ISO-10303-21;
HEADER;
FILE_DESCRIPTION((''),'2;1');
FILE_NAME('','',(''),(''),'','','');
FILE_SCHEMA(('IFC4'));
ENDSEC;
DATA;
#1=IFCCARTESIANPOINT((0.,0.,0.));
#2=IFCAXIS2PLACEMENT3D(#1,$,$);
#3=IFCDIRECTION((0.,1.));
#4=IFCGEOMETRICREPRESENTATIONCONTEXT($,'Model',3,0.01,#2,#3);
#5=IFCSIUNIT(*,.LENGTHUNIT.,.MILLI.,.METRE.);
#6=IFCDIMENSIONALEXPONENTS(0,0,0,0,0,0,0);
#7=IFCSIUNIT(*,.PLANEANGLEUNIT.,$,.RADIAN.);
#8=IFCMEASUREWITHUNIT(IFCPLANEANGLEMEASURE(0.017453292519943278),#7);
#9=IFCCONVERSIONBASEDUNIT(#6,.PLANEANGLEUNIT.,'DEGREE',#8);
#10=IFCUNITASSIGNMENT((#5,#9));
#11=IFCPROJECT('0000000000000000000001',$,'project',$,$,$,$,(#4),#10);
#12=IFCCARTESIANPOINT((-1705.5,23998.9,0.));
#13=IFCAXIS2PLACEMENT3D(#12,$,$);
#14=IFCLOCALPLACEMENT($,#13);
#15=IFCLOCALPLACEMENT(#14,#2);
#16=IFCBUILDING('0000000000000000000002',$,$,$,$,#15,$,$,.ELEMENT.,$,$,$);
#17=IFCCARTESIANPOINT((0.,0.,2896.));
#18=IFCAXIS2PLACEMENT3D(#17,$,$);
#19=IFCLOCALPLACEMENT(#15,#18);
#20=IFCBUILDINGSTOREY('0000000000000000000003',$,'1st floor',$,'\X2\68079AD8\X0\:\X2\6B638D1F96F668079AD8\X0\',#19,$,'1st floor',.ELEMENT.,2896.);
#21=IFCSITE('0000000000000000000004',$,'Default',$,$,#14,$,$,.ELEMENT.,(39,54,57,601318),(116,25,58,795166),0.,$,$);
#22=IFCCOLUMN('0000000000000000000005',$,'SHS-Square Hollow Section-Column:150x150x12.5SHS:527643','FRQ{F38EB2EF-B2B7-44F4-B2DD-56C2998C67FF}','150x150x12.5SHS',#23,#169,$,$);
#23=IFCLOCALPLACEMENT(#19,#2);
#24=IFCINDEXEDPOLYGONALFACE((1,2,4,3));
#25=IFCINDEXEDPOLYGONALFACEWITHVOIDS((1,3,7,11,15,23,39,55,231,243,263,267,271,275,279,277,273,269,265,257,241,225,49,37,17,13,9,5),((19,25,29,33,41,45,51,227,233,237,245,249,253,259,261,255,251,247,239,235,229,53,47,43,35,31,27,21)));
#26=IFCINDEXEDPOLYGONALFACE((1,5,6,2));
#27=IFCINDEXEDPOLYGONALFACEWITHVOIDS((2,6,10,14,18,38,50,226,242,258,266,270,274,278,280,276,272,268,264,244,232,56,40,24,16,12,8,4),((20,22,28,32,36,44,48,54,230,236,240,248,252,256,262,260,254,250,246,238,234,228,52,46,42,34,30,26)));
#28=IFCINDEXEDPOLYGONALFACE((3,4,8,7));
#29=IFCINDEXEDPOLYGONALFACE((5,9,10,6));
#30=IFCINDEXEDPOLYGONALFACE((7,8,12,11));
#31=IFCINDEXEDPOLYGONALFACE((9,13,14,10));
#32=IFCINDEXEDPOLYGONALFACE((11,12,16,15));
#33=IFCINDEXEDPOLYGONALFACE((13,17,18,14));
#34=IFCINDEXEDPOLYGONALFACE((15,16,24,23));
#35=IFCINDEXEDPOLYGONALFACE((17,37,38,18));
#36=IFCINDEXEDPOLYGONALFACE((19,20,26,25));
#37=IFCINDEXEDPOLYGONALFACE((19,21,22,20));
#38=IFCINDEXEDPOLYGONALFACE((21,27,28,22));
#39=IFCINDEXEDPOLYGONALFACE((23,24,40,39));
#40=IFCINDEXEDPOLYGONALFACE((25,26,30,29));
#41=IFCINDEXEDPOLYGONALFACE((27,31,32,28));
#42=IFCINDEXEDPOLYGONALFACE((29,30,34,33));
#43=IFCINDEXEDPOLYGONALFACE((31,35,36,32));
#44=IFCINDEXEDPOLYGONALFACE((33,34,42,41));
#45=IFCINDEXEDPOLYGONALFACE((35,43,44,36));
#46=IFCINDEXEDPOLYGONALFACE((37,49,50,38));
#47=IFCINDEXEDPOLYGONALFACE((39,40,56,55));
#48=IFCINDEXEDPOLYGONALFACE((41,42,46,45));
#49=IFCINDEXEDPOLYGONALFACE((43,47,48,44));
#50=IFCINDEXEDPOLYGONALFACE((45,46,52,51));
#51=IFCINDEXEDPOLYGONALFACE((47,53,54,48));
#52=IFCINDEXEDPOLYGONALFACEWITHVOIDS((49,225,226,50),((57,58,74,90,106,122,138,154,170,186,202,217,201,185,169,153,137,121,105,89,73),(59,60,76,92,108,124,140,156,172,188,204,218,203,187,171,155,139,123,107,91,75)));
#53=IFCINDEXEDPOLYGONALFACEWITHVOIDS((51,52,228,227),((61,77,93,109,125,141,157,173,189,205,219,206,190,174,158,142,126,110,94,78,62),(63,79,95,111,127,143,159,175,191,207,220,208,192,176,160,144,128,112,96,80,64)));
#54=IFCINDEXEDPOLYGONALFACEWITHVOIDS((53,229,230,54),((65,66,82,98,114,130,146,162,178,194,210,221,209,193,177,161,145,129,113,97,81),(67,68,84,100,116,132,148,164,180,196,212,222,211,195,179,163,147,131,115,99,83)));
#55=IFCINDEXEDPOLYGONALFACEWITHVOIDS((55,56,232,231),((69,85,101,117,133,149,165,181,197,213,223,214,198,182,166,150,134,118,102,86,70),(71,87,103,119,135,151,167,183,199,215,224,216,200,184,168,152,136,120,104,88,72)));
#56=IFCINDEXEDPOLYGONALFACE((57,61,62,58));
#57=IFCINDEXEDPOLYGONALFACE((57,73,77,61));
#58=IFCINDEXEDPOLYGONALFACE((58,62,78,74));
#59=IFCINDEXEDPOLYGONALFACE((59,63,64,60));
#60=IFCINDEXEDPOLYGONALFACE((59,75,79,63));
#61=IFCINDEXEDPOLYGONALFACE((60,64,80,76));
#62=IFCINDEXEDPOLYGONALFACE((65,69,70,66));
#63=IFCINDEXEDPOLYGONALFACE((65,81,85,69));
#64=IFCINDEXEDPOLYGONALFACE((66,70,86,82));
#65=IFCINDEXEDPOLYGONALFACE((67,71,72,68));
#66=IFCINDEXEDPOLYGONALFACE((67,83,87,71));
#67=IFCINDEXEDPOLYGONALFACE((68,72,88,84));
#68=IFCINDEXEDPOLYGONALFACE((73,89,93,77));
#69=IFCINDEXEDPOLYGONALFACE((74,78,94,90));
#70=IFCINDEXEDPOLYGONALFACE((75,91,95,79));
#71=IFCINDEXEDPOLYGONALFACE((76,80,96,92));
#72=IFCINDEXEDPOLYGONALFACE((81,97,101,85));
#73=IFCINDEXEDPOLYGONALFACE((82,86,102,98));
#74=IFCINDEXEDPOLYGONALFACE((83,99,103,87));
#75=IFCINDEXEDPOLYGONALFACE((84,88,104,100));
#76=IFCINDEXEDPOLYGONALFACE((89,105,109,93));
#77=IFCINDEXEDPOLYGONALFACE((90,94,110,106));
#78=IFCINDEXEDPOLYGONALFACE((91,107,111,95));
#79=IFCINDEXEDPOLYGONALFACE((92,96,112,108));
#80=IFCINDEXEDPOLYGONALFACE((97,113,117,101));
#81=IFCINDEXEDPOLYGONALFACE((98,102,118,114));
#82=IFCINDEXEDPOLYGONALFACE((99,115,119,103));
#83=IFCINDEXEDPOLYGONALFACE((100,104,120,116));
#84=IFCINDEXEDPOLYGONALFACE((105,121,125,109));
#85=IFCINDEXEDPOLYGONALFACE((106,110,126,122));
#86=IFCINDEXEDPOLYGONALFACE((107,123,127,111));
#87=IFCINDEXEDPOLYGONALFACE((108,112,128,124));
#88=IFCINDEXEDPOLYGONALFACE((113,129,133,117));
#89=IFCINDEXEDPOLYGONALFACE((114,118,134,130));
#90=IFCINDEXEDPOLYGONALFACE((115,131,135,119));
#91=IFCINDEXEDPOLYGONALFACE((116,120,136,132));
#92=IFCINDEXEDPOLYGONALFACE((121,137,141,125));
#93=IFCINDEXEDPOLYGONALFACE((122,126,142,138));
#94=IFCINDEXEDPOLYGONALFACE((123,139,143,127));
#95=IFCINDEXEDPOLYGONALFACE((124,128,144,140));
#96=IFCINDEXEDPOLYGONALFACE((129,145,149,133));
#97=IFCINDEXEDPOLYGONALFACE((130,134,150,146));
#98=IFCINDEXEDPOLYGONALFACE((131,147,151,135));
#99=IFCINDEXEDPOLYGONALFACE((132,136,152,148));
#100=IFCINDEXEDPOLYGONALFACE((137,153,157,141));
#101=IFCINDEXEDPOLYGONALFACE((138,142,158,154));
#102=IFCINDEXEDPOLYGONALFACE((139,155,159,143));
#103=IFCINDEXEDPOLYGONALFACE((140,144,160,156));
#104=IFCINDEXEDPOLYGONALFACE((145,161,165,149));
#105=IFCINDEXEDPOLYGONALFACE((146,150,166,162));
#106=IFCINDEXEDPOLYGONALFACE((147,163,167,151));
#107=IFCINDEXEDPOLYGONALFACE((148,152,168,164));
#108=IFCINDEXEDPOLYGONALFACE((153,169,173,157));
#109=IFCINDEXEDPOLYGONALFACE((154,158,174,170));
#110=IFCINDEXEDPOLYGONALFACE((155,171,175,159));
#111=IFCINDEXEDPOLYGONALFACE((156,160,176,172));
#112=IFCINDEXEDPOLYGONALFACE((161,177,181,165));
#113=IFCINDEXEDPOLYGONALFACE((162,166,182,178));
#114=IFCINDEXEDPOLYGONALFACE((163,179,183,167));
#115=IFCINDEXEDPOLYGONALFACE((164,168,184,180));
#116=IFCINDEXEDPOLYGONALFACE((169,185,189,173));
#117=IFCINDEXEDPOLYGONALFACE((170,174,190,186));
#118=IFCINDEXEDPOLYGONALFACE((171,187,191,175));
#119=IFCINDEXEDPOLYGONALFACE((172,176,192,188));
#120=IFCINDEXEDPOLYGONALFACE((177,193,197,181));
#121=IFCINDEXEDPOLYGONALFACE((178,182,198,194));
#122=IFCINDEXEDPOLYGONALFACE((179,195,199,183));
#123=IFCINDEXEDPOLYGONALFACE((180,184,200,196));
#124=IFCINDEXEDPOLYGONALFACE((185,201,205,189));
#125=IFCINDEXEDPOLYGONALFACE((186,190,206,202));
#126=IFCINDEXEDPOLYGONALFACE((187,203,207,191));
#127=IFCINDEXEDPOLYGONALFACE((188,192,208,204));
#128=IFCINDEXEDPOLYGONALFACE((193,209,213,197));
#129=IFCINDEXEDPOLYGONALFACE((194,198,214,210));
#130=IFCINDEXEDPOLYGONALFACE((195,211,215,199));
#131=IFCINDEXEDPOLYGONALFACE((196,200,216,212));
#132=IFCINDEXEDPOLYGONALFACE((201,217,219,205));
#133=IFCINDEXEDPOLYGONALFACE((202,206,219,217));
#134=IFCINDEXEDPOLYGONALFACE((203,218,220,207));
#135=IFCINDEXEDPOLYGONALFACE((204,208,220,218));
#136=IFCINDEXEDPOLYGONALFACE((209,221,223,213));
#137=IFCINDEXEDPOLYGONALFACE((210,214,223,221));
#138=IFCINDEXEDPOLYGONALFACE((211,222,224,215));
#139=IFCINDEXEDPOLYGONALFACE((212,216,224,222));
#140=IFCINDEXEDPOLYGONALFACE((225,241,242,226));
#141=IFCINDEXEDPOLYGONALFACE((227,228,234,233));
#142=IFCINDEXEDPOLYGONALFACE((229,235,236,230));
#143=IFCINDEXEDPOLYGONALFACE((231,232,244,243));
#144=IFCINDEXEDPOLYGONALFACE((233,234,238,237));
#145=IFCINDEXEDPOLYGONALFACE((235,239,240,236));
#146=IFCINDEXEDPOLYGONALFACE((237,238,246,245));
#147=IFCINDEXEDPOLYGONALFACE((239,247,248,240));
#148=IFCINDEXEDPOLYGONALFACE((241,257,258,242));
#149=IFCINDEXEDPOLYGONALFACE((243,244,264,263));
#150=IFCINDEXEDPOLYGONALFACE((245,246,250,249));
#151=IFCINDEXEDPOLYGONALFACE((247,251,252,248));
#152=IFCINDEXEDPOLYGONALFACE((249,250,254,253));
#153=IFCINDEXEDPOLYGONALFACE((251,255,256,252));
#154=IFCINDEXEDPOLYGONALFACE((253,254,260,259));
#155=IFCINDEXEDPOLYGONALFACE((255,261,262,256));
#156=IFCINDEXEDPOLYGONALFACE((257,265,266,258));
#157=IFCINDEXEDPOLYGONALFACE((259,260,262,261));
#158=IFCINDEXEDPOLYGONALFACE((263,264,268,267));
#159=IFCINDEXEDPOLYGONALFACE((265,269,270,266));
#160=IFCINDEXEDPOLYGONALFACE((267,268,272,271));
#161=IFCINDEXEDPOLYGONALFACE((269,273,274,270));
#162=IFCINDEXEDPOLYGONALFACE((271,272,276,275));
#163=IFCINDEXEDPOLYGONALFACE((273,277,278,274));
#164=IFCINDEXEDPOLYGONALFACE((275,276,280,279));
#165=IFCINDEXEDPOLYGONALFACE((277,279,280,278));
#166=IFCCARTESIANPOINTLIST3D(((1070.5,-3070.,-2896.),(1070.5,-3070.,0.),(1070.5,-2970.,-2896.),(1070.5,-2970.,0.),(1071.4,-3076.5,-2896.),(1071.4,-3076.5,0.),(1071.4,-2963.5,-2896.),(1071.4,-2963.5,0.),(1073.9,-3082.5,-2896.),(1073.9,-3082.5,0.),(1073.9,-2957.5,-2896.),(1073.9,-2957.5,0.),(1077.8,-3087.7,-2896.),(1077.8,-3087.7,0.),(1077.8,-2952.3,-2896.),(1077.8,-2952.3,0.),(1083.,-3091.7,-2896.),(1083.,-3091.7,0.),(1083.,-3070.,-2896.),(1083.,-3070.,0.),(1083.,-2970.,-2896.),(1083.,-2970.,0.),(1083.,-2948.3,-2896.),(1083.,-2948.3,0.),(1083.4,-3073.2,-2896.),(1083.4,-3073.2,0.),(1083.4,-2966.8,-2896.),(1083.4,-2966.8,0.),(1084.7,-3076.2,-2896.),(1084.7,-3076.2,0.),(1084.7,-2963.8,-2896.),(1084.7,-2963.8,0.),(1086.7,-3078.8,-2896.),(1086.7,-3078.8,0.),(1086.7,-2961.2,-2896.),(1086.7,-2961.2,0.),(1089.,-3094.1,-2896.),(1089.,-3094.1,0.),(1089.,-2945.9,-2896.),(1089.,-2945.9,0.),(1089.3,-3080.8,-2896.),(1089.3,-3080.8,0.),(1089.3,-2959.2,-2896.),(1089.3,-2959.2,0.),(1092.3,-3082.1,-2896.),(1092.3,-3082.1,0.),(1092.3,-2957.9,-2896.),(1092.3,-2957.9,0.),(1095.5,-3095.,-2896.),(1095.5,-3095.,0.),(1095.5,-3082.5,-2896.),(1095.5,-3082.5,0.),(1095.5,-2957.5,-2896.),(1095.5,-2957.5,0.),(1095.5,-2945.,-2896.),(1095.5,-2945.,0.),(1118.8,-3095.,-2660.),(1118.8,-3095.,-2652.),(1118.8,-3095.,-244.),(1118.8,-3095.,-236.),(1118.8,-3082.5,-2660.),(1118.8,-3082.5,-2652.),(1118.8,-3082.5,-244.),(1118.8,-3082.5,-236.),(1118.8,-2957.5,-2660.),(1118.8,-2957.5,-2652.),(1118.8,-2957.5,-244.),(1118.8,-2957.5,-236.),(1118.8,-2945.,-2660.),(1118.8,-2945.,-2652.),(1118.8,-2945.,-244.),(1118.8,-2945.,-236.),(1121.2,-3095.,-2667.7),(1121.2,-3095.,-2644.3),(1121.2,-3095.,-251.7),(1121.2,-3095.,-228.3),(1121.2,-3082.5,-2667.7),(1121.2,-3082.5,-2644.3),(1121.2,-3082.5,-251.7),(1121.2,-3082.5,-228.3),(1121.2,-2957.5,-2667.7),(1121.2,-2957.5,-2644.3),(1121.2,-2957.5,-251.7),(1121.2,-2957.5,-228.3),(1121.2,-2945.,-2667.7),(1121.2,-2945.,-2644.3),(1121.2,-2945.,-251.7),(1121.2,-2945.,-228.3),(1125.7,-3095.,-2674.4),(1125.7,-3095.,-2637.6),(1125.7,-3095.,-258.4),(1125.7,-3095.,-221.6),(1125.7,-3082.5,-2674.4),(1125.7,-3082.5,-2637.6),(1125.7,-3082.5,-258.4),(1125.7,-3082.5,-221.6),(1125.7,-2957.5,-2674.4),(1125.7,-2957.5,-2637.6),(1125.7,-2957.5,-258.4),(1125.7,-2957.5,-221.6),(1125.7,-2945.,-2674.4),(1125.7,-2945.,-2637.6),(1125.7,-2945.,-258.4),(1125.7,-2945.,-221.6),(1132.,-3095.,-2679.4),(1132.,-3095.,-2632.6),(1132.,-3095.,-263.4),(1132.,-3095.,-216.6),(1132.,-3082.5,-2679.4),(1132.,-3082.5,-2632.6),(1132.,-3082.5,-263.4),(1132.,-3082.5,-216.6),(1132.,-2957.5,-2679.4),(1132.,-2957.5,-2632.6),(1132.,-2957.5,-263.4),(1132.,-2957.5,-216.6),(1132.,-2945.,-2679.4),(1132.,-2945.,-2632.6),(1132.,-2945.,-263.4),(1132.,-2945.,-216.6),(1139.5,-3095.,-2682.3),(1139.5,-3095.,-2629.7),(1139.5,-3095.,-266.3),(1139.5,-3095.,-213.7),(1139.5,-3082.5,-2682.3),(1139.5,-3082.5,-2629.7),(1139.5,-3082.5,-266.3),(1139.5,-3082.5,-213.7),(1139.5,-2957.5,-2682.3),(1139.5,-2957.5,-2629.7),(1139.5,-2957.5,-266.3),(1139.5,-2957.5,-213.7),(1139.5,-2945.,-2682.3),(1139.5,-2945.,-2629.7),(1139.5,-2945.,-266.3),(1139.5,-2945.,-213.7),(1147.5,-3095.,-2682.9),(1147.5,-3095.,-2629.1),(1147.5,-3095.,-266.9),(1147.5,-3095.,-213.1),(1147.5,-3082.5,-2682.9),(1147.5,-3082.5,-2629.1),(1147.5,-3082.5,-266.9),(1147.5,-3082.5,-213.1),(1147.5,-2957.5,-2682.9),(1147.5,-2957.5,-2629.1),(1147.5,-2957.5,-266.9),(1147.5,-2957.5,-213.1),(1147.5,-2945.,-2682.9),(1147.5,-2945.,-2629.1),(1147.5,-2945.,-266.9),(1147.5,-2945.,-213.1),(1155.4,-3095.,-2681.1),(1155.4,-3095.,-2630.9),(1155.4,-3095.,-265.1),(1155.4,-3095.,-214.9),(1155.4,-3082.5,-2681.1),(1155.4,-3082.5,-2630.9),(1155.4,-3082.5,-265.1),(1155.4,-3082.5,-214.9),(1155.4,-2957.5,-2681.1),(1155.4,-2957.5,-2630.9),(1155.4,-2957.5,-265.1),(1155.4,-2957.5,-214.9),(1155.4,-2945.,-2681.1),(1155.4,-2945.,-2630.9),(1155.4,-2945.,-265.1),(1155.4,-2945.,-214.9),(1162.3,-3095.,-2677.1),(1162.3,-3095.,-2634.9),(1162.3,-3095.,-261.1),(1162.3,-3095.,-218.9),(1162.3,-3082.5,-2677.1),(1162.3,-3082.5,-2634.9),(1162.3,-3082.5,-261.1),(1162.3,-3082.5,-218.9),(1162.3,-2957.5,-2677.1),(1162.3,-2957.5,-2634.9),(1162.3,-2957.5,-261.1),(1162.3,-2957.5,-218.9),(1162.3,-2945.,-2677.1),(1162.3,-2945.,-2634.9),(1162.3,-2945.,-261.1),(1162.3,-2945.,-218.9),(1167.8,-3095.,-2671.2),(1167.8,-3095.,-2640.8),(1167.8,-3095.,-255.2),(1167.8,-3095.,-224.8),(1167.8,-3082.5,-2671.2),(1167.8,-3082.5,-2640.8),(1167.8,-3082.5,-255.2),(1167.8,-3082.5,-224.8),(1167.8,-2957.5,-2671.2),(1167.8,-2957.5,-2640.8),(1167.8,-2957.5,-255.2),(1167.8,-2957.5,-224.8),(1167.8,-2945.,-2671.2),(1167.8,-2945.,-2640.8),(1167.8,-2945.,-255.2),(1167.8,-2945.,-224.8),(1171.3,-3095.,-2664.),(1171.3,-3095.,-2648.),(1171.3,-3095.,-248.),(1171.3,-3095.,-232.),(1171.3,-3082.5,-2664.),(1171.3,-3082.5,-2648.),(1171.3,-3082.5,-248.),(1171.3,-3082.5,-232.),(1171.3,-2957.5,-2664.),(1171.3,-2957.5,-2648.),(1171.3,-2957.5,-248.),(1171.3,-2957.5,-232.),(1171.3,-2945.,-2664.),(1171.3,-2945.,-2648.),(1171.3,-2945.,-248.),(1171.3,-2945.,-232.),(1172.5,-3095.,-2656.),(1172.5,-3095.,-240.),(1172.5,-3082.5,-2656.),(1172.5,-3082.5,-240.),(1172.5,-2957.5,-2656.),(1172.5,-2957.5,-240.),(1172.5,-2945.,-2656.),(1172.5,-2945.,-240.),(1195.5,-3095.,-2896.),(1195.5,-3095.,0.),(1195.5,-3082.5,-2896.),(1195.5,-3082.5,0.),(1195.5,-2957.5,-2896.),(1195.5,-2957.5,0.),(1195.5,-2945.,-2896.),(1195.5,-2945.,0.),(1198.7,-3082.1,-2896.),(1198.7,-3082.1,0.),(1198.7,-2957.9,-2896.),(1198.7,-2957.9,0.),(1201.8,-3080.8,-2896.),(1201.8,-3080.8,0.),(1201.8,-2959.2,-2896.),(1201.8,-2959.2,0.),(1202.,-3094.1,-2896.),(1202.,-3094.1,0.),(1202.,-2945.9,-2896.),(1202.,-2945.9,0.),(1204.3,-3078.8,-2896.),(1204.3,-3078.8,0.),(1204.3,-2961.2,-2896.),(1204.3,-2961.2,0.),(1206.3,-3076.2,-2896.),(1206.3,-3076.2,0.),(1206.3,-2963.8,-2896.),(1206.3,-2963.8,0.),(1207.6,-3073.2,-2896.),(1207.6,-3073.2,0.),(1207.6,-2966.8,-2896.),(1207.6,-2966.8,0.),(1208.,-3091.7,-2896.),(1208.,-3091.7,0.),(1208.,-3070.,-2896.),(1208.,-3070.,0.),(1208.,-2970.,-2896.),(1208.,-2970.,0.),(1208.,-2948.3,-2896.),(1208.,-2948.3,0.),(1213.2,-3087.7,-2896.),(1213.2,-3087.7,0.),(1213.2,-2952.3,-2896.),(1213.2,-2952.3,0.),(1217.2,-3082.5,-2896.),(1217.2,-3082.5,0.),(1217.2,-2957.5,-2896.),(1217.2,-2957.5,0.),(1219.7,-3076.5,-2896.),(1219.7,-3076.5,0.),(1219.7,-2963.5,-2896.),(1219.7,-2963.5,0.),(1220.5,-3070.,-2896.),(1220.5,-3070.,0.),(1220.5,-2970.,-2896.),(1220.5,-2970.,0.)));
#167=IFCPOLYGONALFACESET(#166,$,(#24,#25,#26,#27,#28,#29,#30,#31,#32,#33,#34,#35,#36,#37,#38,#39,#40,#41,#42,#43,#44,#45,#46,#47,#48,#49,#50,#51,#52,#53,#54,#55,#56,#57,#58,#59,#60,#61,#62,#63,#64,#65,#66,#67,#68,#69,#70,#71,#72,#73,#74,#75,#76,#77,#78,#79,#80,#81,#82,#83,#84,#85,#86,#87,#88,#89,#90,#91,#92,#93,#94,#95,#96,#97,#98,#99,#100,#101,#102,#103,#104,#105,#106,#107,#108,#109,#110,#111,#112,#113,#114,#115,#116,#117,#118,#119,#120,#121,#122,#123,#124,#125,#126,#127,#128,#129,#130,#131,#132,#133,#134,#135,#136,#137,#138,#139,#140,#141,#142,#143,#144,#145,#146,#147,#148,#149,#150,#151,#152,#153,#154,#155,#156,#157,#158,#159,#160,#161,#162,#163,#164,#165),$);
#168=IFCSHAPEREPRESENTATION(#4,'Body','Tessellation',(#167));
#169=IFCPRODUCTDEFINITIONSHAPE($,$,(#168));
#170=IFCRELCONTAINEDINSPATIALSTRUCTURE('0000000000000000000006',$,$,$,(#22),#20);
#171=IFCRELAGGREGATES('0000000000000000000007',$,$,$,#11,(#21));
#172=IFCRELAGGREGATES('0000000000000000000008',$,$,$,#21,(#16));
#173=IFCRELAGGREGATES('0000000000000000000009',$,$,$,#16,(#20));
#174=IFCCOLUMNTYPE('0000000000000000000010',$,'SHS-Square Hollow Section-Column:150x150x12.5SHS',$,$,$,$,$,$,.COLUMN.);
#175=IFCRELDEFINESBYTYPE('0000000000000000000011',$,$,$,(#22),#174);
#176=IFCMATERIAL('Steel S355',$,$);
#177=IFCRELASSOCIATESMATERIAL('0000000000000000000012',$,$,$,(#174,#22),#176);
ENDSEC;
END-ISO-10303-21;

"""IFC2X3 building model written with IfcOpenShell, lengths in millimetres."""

from ifc_helpers import new_model, entity, si_unit, converted_unit, direction, frame, frame_2d, origin, origin_2d, place, context, project, spatial, circle_curve, hollow_rectangle, outline, extrude, material, type_object, element, save


model = new_model("IFC2X3")

# Units and contexts
model_context = context("Model", 3, precision=0.01, world=origin(), true_north=direction((0.0, 1.0)))
ifc_project = project(units=[si_unit("LENGTHUNIT", "METRE", prefix="MILLI"), converted_unit("PLANEANGLEUNIT", "DEGREE", entity("IfcPlaneAngleMeasure", 0.017453292519943278), si_unit("PLANEANGLEUNIT", "RADIAN"), dimensions=[0, 0, 0, 0, 0, 0, 0])], contexts=[model_context])

# Site, building, storey
site_placement = place(None, frame((-1705.5, 23998.9, 0.0)))
site = spatial("IfcSite", under=ifc_project, at=site_placement, Name="Default", CompositionType="ELEMENT", RefLatitude=(39, 54, 57, 601318), RefLongitude=(116, 25, 58, 795166), RefElevation=0.0)
building_placement = place(site_placement, origin())
building = spatial("IfcBuilding", under=site, at=building_placement, CompositionType="ELEMENT")
storey_placement = place(building_placement, frame((0.0, 0.0, 2896.0)))
storey = spatial("IfcBuildingStorey", under=building, at=storey_placement, Name="1st floor", ObjectType="标高:正负零标高", LongName="1st floor", CompositionType="ELEMENT", Elevation=2896.0)

# Shared definitions
ifc_material_1 = material(Name="Steel S355")

# Column, openings
column_type_1 = type_object("IfcColumnType", Name="SHS-Square Hollow Section-Column:150x150x12.5SHS", PredefinedType="COLUMN", material=ifc_material_1)
column_1_placement = place(storey_placement, frame((1145.5, -3020.0, 0.0), z_axis=(0.0, 0.0, 1.0), x_axis=(0.0, -1.0, 0.0)))
column_1 = element("IfcColumn", 1, at=column_1_placement, inside=storey, type_object=column_type_1, material=ifc_material_1, Name="SHS-Square Hollow Section-Column:150x150x12.5SHS:527643", Description="FRQ{F38EB2EF-B2B7-44F4-B2DD-56C2998C67FF}", ObjectType="150x150x12.5SHS", context=model_context, shape_type="SweptSolid", body=[
    extrude(hollow_rectangle(XDim=150.0, YDim=150.0, WallThickness=12.5, InnerFilletRadius=12.5, OuterFilletRadius=25.0, at=origin_2d()), origin(), (0.0, 0.0, -1.0), 2896.0),
])
opening_1_placement = place(column_1_placement, frame((-175.1, 0.0, -2896.0), z_axis=(1.0, 0.0, 0.0), x_axis=(0.0, 1.0, 0.0)))
element("IfcOpeningElement", 2, at=opening_1_placement, cuts=column_1, ObjectType="Opening", context=model_context, shape_type="SweptSolid", body=[
    extrude(outline(circle_curve(frame_2d((0.0, 240.0), x_axis=(1.0, 0.0)), 27.0)), origin(), (0.0, 0.0, 1.0), 350.2),
])
opening_2_placement = place(column_1_placement, frame((-175.1, 0.0, 0.0), z_axis=(1.0, 0.0, 0.0), x_axis=(0.0, 1.0, 0.0)))
element("IfcOpeningElement", 3, at=opening_2_placement, cuts=column_1, ObjectType="Opening", context=model_context, shape_type="SweptSolid", body=[
    extrude(outline(circle_curve(frame_2d((0.0, -240.0), x_axis=(1.0, 0.0)), 27.0)), origin(), (0.0, 0.0, 1.0), 350.2),
])

save(model, "model.ifc")
